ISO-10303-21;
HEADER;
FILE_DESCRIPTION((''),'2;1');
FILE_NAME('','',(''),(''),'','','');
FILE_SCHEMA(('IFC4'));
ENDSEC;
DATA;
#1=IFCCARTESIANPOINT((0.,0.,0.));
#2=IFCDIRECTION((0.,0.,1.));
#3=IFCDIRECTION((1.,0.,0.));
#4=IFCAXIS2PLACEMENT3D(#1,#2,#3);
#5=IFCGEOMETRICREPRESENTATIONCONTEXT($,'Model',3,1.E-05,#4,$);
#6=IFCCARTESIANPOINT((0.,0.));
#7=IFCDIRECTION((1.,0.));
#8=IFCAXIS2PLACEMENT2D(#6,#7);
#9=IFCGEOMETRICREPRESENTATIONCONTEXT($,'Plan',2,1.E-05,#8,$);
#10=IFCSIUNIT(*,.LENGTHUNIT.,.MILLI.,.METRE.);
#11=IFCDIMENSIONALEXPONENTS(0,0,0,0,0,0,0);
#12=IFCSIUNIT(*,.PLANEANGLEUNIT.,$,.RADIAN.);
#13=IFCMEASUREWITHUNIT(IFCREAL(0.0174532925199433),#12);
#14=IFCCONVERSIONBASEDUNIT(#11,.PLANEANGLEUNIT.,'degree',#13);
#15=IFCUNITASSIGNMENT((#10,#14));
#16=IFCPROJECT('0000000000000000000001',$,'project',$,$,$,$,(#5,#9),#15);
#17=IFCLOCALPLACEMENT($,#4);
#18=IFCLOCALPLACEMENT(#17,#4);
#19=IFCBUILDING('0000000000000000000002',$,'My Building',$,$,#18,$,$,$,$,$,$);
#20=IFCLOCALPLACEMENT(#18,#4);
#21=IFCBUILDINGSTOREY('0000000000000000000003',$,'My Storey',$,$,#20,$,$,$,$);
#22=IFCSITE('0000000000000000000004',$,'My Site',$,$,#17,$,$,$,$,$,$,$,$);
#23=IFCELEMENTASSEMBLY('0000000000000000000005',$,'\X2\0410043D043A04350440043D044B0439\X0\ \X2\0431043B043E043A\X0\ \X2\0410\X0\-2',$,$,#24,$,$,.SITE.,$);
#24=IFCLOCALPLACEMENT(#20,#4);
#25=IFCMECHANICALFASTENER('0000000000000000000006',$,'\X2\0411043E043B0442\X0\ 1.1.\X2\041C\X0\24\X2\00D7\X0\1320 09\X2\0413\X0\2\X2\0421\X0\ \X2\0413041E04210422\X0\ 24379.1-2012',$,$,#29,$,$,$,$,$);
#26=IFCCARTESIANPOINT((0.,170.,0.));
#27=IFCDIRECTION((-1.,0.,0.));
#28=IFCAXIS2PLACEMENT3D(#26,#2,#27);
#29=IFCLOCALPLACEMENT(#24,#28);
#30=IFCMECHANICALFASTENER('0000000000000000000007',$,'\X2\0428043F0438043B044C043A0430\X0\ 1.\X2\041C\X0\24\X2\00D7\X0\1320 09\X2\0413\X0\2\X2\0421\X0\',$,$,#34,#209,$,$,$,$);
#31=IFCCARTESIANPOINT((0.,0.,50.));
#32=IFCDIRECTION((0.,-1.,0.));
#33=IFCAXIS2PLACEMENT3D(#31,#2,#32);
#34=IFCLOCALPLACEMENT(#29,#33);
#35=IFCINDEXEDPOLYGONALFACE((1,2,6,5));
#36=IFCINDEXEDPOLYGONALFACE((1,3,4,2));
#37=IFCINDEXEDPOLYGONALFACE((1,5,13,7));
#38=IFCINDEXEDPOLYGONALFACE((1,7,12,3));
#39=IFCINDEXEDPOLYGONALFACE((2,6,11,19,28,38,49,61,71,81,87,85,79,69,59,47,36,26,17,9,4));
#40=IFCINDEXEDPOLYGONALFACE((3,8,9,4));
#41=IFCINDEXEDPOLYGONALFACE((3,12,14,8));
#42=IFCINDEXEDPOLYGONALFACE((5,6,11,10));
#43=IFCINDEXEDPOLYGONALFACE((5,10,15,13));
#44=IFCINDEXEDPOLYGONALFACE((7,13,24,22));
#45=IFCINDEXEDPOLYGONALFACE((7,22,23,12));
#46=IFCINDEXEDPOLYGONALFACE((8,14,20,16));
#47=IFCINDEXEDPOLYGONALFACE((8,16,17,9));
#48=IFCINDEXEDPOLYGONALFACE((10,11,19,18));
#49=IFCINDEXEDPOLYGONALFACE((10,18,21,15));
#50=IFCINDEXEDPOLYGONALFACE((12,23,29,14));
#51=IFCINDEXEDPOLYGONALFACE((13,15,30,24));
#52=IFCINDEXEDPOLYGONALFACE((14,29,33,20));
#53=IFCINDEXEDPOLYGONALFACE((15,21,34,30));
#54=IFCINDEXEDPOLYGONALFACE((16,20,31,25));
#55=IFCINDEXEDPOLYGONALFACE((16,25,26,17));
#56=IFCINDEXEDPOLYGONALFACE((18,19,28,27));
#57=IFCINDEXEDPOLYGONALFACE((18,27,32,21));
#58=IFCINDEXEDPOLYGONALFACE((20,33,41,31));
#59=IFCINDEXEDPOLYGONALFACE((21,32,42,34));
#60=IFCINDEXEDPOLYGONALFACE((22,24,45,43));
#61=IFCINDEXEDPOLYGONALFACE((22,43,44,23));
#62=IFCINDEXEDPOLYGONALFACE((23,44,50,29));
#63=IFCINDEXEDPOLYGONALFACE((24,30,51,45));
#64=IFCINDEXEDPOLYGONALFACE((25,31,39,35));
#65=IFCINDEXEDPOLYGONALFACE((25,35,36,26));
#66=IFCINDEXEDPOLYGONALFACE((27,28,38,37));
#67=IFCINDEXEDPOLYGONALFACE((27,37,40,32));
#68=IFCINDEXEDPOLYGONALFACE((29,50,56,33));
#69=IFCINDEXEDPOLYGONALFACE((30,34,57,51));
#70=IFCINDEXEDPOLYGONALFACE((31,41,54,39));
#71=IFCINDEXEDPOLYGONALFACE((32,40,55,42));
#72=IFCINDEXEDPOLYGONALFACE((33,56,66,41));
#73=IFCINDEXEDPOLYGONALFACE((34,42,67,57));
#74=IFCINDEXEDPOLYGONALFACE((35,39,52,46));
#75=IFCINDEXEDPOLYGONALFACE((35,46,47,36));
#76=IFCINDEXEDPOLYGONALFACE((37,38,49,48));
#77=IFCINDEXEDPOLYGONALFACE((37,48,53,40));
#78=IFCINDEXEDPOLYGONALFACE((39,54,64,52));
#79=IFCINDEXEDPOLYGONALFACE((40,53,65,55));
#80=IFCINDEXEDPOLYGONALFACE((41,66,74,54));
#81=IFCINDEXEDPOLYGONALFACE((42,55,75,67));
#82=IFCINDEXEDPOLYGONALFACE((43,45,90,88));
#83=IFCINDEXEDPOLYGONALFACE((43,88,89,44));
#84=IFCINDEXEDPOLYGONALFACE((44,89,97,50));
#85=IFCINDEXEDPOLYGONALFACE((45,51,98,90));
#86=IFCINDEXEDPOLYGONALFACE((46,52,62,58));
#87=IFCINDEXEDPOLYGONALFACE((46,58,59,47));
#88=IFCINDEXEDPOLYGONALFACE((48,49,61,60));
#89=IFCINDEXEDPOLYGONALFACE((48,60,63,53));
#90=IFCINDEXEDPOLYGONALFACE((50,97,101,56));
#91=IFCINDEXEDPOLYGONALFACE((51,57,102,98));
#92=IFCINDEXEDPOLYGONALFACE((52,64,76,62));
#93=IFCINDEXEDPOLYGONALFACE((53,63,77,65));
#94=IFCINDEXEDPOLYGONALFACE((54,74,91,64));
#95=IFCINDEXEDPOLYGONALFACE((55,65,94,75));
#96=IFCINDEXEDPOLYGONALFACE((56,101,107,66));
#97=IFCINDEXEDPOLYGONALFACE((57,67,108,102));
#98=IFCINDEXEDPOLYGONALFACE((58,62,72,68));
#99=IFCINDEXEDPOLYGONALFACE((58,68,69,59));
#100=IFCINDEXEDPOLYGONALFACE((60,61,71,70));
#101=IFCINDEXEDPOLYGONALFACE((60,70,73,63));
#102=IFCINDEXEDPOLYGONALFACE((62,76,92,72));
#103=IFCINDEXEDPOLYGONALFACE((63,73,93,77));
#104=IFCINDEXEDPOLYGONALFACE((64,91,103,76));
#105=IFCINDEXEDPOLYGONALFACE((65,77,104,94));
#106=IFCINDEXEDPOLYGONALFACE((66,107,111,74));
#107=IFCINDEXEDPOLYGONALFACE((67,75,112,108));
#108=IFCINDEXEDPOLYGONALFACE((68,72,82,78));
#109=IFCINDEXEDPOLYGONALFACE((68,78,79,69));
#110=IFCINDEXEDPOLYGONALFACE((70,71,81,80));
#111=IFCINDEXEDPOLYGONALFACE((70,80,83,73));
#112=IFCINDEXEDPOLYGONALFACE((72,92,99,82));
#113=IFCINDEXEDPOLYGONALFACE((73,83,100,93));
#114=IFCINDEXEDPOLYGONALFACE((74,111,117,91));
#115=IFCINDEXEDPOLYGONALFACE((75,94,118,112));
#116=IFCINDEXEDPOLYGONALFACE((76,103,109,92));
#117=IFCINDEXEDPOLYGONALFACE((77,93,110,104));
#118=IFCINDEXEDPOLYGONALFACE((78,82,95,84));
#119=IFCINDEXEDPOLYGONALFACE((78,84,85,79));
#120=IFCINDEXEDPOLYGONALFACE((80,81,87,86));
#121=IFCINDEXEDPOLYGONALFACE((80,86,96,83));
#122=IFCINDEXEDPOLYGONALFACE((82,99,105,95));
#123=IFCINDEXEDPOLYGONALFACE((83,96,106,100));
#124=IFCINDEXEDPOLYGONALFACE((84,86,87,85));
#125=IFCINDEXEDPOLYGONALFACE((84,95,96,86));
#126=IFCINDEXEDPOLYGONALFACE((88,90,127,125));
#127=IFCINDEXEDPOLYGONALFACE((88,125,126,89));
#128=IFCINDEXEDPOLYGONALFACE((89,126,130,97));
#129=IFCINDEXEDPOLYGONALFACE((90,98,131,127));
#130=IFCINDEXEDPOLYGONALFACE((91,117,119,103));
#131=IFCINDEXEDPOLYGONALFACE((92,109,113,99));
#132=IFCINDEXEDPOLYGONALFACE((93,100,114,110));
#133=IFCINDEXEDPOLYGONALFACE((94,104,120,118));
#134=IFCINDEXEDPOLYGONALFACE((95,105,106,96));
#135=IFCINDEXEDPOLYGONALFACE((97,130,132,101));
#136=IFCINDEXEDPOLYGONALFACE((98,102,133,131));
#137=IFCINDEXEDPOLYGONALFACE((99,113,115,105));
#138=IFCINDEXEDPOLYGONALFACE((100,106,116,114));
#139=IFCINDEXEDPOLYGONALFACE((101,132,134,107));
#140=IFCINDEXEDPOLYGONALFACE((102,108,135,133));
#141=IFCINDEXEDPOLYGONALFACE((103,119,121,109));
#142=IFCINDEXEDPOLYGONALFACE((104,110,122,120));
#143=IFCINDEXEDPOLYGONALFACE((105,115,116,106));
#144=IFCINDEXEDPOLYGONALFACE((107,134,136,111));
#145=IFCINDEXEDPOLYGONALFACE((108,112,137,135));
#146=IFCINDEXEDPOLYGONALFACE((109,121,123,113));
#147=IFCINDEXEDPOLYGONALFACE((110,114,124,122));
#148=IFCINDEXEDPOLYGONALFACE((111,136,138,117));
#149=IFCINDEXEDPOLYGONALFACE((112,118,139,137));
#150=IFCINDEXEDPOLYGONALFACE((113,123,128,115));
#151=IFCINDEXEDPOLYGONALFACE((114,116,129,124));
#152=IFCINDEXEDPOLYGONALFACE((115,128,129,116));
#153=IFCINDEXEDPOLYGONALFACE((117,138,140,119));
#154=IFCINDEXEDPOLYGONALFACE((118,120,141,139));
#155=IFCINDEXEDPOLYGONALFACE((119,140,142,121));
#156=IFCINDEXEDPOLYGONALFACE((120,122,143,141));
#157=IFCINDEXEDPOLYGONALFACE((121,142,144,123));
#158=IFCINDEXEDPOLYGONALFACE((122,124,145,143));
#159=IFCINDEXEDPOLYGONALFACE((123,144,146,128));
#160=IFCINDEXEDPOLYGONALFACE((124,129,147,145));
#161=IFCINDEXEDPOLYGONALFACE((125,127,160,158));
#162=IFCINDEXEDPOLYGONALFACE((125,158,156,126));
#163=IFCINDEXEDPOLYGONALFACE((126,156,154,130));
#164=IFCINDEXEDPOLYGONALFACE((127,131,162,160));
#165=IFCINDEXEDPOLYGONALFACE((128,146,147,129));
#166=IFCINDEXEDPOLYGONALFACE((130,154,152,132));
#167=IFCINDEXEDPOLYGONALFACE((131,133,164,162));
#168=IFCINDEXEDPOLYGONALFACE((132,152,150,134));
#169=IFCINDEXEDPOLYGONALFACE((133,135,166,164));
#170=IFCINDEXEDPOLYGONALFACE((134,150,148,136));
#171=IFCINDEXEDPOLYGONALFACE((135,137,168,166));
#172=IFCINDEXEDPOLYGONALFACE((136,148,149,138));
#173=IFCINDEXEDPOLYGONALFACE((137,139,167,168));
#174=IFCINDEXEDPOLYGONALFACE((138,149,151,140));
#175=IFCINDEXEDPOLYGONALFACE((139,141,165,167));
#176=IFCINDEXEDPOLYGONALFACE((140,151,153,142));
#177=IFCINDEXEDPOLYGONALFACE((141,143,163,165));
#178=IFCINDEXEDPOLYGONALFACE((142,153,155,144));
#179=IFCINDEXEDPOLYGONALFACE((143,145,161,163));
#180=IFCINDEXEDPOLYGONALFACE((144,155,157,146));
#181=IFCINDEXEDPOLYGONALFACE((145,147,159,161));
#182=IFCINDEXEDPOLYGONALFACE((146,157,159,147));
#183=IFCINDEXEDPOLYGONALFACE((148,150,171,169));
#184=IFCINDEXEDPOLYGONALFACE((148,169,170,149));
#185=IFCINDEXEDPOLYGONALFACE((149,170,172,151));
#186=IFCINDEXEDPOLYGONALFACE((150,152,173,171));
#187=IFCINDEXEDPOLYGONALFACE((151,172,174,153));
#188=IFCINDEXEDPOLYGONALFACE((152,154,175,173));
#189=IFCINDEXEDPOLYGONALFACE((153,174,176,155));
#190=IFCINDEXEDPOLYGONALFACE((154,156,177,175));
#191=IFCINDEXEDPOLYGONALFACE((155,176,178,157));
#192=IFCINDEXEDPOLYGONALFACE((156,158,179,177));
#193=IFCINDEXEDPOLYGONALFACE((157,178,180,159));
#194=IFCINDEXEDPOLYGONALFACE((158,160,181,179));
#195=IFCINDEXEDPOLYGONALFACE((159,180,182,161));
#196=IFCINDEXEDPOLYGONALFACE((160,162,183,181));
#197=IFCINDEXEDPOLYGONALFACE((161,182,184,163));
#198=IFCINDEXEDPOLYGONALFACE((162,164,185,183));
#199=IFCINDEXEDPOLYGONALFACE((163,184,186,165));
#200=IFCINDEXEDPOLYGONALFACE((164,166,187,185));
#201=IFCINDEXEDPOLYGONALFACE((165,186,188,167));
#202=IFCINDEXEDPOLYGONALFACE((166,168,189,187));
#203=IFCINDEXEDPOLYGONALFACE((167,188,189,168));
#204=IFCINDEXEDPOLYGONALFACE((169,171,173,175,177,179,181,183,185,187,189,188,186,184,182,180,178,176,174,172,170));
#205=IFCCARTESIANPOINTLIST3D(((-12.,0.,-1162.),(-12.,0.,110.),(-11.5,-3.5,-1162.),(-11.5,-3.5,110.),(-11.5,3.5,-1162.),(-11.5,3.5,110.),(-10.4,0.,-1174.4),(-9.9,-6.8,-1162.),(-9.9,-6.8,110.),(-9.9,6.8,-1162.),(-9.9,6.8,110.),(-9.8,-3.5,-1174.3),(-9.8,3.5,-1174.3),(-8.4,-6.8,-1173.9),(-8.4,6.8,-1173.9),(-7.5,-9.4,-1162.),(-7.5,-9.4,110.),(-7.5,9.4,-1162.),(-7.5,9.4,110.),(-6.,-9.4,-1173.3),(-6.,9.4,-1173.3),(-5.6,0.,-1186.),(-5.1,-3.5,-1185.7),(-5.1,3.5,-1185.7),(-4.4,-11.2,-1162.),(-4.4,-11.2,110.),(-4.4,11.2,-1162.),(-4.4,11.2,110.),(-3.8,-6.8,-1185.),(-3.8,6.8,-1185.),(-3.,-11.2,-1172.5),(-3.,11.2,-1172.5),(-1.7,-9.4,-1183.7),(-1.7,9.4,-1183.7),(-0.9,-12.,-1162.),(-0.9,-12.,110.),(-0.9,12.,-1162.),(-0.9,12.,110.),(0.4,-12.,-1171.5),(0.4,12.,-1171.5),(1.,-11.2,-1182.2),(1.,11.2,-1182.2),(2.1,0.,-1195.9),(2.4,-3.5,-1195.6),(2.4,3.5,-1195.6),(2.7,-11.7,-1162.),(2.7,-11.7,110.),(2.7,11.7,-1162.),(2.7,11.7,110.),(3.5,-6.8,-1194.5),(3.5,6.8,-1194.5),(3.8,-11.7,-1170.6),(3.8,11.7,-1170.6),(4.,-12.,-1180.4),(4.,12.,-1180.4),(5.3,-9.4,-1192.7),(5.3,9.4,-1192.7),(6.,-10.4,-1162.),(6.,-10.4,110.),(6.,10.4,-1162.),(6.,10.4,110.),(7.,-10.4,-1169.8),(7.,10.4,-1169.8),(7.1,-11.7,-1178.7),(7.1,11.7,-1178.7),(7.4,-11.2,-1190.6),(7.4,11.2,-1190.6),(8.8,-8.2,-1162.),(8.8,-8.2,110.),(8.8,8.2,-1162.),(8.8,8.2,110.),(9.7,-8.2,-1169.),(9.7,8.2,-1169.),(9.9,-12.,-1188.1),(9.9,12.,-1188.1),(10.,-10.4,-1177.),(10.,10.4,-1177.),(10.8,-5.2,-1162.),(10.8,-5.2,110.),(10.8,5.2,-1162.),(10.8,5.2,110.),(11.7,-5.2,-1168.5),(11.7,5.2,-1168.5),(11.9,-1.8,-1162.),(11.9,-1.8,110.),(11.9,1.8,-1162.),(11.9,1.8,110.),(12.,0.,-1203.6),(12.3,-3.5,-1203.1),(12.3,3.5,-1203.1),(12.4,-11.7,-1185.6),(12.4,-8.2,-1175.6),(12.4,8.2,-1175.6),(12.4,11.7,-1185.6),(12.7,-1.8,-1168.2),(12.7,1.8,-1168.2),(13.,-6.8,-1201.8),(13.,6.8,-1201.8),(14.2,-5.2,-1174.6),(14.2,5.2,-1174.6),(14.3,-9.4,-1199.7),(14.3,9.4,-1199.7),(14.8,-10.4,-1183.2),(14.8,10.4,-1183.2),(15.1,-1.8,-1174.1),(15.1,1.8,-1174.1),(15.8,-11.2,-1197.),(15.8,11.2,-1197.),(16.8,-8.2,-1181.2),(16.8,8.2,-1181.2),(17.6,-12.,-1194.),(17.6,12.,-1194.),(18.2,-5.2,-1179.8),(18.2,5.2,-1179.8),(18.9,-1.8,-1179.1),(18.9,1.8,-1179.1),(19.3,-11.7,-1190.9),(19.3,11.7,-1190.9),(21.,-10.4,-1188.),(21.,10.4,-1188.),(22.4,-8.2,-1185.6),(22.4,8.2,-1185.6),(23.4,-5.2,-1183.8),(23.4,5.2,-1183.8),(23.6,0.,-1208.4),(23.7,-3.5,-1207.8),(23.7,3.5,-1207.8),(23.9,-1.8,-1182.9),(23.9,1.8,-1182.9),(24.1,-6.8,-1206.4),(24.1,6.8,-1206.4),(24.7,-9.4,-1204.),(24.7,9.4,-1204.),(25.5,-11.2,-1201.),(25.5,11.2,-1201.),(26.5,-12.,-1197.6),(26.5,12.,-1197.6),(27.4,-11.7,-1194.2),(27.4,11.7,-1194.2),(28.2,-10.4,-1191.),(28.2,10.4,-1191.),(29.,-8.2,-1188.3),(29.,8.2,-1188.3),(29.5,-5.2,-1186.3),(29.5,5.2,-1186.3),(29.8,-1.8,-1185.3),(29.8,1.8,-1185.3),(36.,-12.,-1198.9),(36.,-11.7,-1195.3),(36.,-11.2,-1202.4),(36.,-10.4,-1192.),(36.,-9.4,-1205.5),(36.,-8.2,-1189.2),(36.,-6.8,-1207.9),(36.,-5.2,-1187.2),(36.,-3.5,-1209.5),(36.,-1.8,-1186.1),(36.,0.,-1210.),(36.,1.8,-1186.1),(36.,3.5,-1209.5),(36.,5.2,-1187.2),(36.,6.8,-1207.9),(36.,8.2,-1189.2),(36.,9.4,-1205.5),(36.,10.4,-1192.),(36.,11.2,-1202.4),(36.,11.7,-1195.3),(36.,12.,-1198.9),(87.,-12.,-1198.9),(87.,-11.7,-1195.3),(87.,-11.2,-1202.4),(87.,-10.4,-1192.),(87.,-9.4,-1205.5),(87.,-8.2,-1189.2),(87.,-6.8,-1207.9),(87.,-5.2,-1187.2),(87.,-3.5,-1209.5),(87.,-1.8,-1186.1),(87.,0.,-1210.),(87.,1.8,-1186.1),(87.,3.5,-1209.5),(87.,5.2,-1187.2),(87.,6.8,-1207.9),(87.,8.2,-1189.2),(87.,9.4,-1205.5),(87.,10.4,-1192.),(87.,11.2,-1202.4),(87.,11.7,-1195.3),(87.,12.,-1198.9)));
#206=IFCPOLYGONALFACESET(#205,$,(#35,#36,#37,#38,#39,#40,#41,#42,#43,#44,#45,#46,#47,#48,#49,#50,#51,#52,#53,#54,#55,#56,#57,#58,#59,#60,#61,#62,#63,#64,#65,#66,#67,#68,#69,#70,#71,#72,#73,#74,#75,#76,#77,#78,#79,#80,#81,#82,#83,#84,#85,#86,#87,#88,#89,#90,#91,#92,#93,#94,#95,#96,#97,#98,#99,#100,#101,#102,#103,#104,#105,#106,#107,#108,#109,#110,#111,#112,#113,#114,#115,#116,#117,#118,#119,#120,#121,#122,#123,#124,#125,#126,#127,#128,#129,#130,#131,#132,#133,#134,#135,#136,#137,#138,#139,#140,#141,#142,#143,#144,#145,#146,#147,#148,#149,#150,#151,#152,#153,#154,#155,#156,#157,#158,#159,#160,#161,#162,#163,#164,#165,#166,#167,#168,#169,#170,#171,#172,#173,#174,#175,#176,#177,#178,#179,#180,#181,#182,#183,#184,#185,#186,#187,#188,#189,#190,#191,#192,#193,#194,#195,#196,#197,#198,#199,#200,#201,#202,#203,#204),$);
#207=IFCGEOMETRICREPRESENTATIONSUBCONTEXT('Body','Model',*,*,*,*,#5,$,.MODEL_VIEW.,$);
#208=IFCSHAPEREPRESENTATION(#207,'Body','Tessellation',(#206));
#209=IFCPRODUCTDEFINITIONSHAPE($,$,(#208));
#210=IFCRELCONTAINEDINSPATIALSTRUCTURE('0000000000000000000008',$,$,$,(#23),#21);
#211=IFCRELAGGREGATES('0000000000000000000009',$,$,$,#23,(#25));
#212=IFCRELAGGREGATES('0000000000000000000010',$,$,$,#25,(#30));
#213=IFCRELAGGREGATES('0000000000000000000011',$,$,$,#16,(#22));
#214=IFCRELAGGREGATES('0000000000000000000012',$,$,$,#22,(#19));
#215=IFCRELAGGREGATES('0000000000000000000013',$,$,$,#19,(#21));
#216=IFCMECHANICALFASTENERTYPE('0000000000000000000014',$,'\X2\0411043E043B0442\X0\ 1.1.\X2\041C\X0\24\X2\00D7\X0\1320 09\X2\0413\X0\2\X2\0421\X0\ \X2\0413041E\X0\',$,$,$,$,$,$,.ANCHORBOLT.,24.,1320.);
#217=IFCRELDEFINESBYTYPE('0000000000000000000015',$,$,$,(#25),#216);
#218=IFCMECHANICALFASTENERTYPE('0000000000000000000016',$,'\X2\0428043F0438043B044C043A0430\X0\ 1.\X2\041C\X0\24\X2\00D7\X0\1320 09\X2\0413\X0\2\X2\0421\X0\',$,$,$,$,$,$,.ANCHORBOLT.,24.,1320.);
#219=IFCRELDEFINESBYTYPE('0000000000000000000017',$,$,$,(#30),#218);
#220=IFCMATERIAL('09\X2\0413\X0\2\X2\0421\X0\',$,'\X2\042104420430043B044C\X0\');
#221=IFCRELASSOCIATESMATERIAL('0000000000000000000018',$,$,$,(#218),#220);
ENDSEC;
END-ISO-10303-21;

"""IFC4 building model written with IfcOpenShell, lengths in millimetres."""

from ifc_helpers import new_model, entity, si_unit, converted_unit, frame, origin_with_axes, origin_2d_with_axis, place, context, subcontext, project, spatial, source, transform, mapped, material, type_object, type_shapes, element, aggregate, save


model = new_model("IFC4")

# Units and contexts
model_context = context("Model", 3, precision=1e-05, world=origin_with_axes())
plan_context = context("Plan", 2, precision=1e-05, world=origin_2d_with_axis())
body_context = subcontext(model_context, "Body", "Model", "MODEL_VIEW")
ifc_project = project(units=[si_unit("LENGTHUNIT", "METRE", prefix="MILLI"), converted_unit("PLANEANGLEUNIT", "degree", entity("IfcReal", 0.0174532925199433), si_unit("PLANEANGLEUNIT", "RADIAN"), dimensions=[0, 0, 0, 0, 0, 0, 0])], contexts=[model_context, plan_context])

# Site, building, storey
site_placement = place(None, origin_with_axes())
site = spatial("IfcSite", under=ifc_project, at=site_placement, Name="My Site")
building_placement = place(site_placement, origin_with_axes())
building = spatial("IfcBuilding", under=site, at=building_placement, Name="My Building")
storey_placement = place(building_placement, origin_with_axes())
storey = spatial("IfcBuildingStorey", under=building, at=storey_placement, Name="My Storey")

# Shared definitions
placement_1 = place(storey_placement, origin_with_axes())

# Element assembly, mechanical fasteners
assembly_1 = element("IfcElementAssembly", 1, at=placement_1, inside=storey, Name="Анкерный блок А-2", AssemblyPlace="SITE")
ifc_material_1 = material(Name="09Г2С", Category="Сталь")
mechanical_fastener_type_1 = type_object("IfcMechanicalFastenerType", Name="Шпилька 1.М24×1320 09Г2С", NominalDiameter=24.0, NominalLength=1320.0, PredefinedType="ANCHORBOLT", material=ifc_material_1)
shared_shape_1 = source(frame((0.0, 0.0, 110.0), z_axis=(0.0, 0.0, 1.0), x_axis=(1.0, 0.0, 0.0)), body_context, "Body", "AdvancedSweptSolid", [
    entity("IfcSweptDiskSolid", entity("IfcIndexedPolyCurve", entity("IfcCartesianPointList3D", [[0.0, 0.0, 0.0], [0.0, 0.0, -1272.0], [10.5, 0.0, -1297.5], [36.0, 0.0, -1308.0], [87.0, 0.0, -1308.0]]), [entity("IfcLineIndex", [1, 2]), entity("IfcArcIndex", [2, 3, 4]), entity("IfcLineIndex", [4, 5])]), 12.0),
])
type_shapes(mechanical_fastener_type_1, [shared_shape_1])
mechanical_fastener_type_2 = type_object("IfcMechanicalFastenerType", Name="Болт 1.1.М24×1320 09Г2С ГО", NominalDiameter=24.0, NominalLength=1320.0, PredefinedType="ANCHORBOLT")
mechanical_fastener_1_placement = place(placement_1, frame((0.0, 170.0, 0.0), z_axis=(0.0, 0.0, 1.0), x_axis=(-1.0, 0.0, 0.0)))
mechanical_fastener_1 = element("IfcMechanicalFastener", 2, at=mechanical_fastener_1_placement, type_object=mechanical_fastener_type_2, Name="Болт 1.1.М24×1320 09Г2С ГОСТ 24379.1-2012")
aggregate(assembly_1, [mechanical_fastener_1])
mechanical_fastener_2_placement = place(mechanical_fastener_1_placement, frame((0.0, 0.0, 50.0), z_axis=(0.0, 0.0, 1.0), x_axis=(0.0, -1.0, 0.0)))
mechanical_fastener_2 = element("IfcMechanicalFastener", 3, at=mechanical_fastener_2_placement, type_object=mechanical_fastener_type_1, Name="Шпилька 1.М24×1320 09Г2С", context=body_context, shape_type="MappedRepresentation", body=[
    mapped(shared_shape_1, transform((0.0, 0.0, 0.0), x_axis=(1.0, 0.0, 0.0), y_axis=(0.0, 1.0, 0.0), z_axis=(0.0, 0.0, 1.0), scale=1.0)),
])

aggregate(mechanical_fastener_1, [mechanical_fastener_2])

save(model, "model.ifc")
